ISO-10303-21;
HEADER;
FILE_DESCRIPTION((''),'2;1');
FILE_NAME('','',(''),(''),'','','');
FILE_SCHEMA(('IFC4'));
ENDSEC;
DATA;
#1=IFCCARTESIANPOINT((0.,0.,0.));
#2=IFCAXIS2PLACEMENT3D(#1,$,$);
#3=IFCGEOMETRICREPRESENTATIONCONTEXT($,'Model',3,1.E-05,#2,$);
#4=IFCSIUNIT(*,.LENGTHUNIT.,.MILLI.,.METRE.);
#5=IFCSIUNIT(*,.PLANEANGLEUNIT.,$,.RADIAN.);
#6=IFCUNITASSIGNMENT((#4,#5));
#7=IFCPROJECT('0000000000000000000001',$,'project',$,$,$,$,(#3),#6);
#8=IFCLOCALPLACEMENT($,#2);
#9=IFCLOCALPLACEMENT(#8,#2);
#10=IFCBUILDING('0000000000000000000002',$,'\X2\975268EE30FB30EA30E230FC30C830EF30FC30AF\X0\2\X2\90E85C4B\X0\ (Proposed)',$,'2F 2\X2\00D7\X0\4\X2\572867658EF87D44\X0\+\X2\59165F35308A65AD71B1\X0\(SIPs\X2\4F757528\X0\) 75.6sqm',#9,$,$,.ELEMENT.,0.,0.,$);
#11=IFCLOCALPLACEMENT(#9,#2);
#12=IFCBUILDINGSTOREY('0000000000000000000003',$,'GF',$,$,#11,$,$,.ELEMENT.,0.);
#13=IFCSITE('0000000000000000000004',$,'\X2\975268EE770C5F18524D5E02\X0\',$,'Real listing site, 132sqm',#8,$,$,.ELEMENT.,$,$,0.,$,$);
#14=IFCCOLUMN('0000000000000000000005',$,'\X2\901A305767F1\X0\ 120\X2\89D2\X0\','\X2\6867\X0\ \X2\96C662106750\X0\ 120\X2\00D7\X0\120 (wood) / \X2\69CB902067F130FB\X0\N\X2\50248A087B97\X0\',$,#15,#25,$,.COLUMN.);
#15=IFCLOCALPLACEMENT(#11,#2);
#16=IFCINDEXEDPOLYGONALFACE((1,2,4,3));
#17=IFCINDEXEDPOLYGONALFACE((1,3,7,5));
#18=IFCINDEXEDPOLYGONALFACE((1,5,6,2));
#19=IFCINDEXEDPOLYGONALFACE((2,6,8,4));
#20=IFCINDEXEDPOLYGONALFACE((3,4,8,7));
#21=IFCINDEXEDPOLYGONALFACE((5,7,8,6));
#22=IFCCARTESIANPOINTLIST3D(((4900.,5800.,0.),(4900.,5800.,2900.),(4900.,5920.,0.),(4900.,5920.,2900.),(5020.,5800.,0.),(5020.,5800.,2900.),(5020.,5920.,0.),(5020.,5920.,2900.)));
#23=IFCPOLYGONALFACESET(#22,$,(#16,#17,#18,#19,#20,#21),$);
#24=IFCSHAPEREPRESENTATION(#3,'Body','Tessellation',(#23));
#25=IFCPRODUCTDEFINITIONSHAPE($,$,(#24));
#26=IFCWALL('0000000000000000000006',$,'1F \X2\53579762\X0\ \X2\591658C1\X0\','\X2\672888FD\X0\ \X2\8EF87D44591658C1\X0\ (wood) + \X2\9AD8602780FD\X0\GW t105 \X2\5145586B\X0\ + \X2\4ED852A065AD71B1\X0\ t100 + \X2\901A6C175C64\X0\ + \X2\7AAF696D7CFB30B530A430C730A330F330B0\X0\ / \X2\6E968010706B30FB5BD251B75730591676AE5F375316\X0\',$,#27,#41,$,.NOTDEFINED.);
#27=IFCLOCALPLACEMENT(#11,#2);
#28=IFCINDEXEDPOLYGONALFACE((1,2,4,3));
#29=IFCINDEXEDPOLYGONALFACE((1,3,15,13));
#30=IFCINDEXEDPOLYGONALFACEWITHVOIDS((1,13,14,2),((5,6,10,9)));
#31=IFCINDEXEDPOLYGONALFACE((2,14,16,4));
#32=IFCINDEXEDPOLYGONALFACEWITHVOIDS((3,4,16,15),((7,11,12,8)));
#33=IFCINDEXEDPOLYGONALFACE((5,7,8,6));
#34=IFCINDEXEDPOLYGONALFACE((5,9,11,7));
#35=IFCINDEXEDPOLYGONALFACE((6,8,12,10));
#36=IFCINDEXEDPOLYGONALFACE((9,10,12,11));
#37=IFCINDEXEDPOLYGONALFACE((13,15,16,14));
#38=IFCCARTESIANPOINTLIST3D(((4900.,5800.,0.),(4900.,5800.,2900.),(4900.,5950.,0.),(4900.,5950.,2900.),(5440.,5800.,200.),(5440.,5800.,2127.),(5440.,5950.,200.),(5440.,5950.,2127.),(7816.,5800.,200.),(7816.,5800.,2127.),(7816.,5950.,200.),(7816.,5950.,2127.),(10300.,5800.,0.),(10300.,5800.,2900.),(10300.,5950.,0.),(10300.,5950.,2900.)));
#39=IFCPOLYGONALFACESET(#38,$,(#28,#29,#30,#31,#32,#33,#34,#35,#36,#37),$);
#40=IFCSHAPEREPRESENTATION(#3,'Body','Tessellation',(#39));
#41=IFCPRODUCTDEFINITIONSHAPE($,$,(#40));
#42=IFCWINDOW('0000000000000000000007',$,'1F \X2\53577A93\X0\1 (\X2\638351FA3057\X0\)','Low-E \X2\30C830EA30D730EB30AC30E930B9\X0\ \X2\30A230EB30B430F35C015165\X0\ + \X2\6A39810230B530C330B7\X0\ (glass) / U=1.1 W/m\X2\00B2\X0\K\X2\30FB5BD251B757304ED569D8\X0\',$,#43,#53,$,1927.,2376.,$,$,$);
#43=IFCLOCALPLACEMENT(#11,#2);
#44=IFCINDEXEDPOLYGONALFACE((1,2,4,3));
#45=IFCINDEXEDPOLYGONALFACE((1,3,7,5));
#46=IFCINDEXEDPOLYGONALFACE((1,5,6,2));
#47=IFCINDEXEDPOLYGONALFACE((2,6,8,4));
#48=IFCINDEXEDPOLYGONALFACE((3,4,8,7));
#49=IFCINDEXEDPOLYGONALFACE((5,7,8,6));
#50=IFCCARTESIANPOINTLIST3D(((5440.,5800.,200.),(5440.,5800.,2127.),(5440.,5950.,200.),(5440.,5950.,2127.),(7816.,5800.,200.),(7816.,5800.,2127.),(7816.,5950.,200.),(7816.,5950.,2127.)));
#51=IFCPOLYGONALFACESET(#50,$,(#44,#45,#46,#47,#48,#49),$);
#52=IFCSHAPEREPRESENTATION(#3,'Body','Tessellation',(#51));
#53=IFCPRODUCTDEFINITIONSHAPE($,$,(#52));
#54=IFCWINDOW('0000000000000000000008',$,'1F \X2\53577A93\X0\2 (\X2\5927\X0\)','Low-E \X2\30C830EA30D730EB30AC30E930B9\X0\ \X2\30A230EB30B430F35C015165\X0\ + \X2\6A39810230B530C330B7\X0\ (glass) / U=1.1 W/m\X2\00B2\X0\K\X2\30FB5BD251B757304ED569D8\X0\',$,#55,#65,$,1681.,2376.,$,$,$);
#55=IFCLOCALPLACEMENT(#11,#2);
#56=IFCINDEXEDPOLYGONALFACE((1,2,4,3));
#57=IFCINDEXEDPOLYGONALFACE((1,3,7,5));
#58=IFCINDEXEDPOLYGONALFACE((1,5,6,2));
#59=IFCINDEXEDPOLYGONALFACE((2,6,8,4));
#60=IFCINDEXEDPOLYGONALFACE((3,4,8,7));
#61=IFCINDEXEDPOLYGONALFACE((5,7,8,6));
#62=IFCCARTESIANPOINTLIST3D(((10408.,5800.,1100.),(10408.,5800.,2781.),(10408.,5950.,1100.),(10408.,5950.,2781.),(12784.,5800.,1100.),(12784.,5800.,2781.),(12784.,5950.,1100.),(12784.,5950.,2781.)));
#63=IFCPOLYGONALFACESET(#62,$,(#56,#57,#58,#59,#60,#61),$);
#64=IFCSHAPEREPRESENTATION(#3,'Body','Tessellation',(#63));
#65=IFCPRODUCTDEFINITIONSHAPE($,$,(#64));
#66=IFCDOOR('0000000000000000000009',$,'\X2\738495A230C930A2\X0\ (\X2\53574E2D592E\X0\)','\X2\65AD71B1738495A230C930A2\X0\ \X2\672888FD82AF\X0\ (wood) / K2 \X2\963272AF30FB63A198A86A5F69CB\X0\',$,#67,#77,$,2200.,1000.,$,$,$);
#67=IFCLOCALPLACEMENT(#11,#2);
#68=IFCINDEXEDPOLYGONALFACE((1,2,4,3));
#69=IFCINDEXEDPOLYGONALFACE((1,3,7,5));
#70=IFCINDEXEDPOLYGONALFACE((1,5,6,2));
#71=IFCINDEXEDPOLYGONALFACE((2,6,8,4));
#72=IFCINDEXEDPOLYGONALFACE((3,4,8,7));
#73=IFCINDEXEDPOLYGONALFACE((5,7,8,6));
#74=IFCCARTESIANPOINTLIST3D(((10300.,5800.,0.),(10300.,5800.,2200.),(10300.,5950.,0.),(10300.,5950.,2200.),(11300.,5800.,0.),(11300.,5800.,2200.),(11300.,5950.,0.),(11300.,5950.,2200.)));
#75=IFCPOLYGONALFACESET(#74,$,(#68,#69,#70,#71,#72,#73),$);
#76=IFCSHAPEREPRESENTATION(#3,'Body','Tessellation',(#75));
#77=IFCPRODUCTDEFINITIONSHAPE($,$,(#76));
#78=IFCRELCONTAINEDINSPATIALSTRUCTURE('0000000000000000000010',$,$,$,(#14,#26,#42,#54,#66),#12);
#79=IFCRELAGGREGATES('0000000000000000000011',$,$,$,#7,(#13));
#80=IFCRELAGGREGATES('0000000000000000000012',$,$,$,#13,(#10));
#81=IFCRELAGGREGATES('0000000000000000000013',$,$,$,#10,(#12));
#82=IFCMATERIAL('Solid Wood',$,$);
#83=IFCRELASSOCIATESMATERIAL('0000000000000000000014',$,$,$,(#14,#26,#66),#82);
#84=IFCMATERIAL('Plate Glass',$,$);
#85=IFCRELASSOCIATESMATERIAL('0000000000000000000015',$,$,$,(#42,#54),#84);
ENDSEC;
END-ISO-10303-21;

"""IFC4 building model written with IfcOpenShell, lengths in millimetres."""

from ifc_helpers import new_model, si_unit, frame, frame_2d, origin, place, context, project, spatial, rectangle, extrude, material, element, fill, save


model = new_model("IFC4")

# Units and contexts
model_context = context("Model", 3, precision=1e-05, world=origin())
ifc_project = project(units=[si_unit("LENGTHUNIT", "METRE", prefix="MILLI"), si_unit("PLANEANGLEUNIT", "RADIAN")], contexts=[model_context])

# Site, building, storey
site_placement = place(None, origin())
site = spatial("IfcSite", under=ifc_project, at=site_placement, Name="青森県弘前市", ObjectType="Real listing site, 132sqm", CompositionType="ELEMENT", RefElevation=0.0)
building_placement = place(site_placement, origin())
building = spatial("IfcBuilding", under=site, at=building_placement, Name="青森・リモートワーク2部屋 (Proposed)", ObjectType="2F 2×4在来軸組+外張り断熱(SIPs併用) 75.6sqm", CompositionType="ELEMENT", ElevationOfRefHeight=0.0, ElevationOfTerrain=0.0)
storey_placement = place(building_placement, origin())
storey = spatial("IfcBuildingStorey", under=building, at=storey_placement, Name="GF", CompositionType="ELEMENT", Elevation=0.0)

# Column
ifc_material_1 = material(Name="Solid Wood")
column_placement = place(storey_placement, frame((2450.0, 2900.0, 0.0)))
element("IfcColumn", 1, at=column_placement, inside=storey, material=ifc_material_1, Name="通し柱 120角", Description="桧 集成材 120×120 (wood) / 構造柱・N値計算", PredefinedType="COLUMN", context=model_context, shape_type="SweptSolid", body=[
    extrude(rectangle(XDim=120.0, YDim=120.0, at=frame_2d((60.0, 60.0))), frame((2450.0, 2900.0, 0.0)), (0.0, 0.0, 1.0), 2900.0),
])

# Wall, openings, windows, door
wall_1_placement = place(storey_placement, frame((2450.0, 2900.0, 0.0)))
wall_1 = element("IfcWall", 2, at=wall_1_placement, inside=storey, material=ifc_material_1, Name="1F 南面 外壁", Description="木製 軸組外壁 (wood) + 高性能GW t105 充填 + 付加断熱 t100 + 通気層 + 窯業系サイディング / 準耐火・寒冷地外皮強化", PredefinedType="NOTDEFINED", context=model_context, shape_type="SweptSolid", body=[
    extrude(rectangle(XDim=5400.0, YDim=150.0, at=frame_2d((2700.0, 75.0))), frame((2450.0, 2900.0, 0.0)), (0.0, 0.0, 1.0), 2900.0),
])
opening_1_placement = place(storey_placement, frame((2720.0, 2900.0, 100.0)))
opening_1 = element("IfcOpeningElement", 3, at=opening_1_placement, cuts=wall_1, PredefinedType="NOTDEFINED", context=model_context, shape_type="SweptSolid", body=[
    extrude(rectangle(XDim=2376.0, YDim=150.0, at=frame_2d((1188.0, 75.0))), frame((2720.0, 2900.0, 100.0)), (0.0, 0.0, 1.0), 1927.0),
])
opening_2_placement = place(storey_placement, frame((5204.0, 2900.0, 550.0)))
opening_2 = element("IfcOpeningElement", 4, at=opening_2_placement, cuts=wall_1, PredefinedType="NOTDEFINED", context=model_context, shape_type="SweptSolid", body=[
    extrude(rectangle(XDim=2376.0, YDim=150.0, at=frame_2d((1188.0, 75.0))), frame((5204.0, 2900.0, 550.0)), (0.0, 0.0, 1.0), 1681.0),
])
opening_3_placement = place(storey_placement, frame((5150.0, 2900.0, 0.0)))
opening_3 = element("IfcOpeningElement", 5, at=opening_3_placement, cuts=wall_1, PredefinedType="NOTDEFINED", context=model_context, shape_type="SweptSolid", body=[
    extrude(rectangle(XDim=1000.0, YDim=150.0, at=frame_2d((500.0, 75.0))), frame((5150.0, 2900.0, 0.0)), (0.0, 0.0, 1.0), 2200.0),
])
ifc_material_2 = material(Name="Plate Glass")
window_1_placement = place(storey_placement, frame((2720.0, 2900.0, 100.0)))
window_1 = element("IfcWindow", 6, at=window_1_placement, inside=storey, material=ifc_material_2, Name="1F 南窓1 (掃出し)", Description="Low-E トリプルガラス アルゴン封入 + 樹脂サッシ (glass) / U=1.1 W/m²K・寒冷地仕様", OverallHeight=1927.0, OverallWidth=2376.0, context=model_context, shape_type="SweptSolid", body=[
    extrude(rectangle(XDim=2376.0, YDim=150.0, at=frame_2d((1188.0, 75.0))), frame((2720.0, 2900.0, 100.0)), (0.0, 0.0, 1.0), 1927.0),
])
fill(opening_1, window_1)
window_2_placement = place(storey_placement, frame((5204.0, 2900.0, 550.0)))
window_2 = element("IfcWindow", 7, at=window_2_placement, inside=storey, material=ifc_material_2, Name="1F 南窓2 (大)", Description="Low-E トリプルガラス アルゴン封入 + 樹脂サッシ (glass) / U=1.1 W/m²K・寒冷地仕様", OverallHeight=1681.0, OverallWidth=2376.0, context=model_context, shape_type="SweptSolid", body=[
    extrude(rectangle(XDim=2376.0, YDim=150.0, at=frame_2d((1188.0, 75.0))), frame((5204.0, 2900.0, 550.0)), (0.0, 0.0, 1.0), 1681.0),
])
fill(opening_2, window_2)
door_placement = place(storey_placement, frame((5150.0, 2900.0, 0.0)))
door = element("IfcDoor", 8, at=door_placement, inside=storey, material=ifc_material_1, Name="玄関ドア (南中央)", Description="断熱玄関ドア 木製芯 (wood) / K2 防犯・採風機構", OverallHeight=2200.0, OverallWidth=1000.0, context=model_context, shape_type="SweptSolid", body=[
    extrude(rectangle(XDim=1000.0, YDim=150.0, at=frame_2d((500.0, 75.0))), frame((5150.0, 2900.0, 0.0)), (0.0, 0.0, 1.0), 2200.0),
])
fill(opening_3, door)

save(model, "model.ifc")
